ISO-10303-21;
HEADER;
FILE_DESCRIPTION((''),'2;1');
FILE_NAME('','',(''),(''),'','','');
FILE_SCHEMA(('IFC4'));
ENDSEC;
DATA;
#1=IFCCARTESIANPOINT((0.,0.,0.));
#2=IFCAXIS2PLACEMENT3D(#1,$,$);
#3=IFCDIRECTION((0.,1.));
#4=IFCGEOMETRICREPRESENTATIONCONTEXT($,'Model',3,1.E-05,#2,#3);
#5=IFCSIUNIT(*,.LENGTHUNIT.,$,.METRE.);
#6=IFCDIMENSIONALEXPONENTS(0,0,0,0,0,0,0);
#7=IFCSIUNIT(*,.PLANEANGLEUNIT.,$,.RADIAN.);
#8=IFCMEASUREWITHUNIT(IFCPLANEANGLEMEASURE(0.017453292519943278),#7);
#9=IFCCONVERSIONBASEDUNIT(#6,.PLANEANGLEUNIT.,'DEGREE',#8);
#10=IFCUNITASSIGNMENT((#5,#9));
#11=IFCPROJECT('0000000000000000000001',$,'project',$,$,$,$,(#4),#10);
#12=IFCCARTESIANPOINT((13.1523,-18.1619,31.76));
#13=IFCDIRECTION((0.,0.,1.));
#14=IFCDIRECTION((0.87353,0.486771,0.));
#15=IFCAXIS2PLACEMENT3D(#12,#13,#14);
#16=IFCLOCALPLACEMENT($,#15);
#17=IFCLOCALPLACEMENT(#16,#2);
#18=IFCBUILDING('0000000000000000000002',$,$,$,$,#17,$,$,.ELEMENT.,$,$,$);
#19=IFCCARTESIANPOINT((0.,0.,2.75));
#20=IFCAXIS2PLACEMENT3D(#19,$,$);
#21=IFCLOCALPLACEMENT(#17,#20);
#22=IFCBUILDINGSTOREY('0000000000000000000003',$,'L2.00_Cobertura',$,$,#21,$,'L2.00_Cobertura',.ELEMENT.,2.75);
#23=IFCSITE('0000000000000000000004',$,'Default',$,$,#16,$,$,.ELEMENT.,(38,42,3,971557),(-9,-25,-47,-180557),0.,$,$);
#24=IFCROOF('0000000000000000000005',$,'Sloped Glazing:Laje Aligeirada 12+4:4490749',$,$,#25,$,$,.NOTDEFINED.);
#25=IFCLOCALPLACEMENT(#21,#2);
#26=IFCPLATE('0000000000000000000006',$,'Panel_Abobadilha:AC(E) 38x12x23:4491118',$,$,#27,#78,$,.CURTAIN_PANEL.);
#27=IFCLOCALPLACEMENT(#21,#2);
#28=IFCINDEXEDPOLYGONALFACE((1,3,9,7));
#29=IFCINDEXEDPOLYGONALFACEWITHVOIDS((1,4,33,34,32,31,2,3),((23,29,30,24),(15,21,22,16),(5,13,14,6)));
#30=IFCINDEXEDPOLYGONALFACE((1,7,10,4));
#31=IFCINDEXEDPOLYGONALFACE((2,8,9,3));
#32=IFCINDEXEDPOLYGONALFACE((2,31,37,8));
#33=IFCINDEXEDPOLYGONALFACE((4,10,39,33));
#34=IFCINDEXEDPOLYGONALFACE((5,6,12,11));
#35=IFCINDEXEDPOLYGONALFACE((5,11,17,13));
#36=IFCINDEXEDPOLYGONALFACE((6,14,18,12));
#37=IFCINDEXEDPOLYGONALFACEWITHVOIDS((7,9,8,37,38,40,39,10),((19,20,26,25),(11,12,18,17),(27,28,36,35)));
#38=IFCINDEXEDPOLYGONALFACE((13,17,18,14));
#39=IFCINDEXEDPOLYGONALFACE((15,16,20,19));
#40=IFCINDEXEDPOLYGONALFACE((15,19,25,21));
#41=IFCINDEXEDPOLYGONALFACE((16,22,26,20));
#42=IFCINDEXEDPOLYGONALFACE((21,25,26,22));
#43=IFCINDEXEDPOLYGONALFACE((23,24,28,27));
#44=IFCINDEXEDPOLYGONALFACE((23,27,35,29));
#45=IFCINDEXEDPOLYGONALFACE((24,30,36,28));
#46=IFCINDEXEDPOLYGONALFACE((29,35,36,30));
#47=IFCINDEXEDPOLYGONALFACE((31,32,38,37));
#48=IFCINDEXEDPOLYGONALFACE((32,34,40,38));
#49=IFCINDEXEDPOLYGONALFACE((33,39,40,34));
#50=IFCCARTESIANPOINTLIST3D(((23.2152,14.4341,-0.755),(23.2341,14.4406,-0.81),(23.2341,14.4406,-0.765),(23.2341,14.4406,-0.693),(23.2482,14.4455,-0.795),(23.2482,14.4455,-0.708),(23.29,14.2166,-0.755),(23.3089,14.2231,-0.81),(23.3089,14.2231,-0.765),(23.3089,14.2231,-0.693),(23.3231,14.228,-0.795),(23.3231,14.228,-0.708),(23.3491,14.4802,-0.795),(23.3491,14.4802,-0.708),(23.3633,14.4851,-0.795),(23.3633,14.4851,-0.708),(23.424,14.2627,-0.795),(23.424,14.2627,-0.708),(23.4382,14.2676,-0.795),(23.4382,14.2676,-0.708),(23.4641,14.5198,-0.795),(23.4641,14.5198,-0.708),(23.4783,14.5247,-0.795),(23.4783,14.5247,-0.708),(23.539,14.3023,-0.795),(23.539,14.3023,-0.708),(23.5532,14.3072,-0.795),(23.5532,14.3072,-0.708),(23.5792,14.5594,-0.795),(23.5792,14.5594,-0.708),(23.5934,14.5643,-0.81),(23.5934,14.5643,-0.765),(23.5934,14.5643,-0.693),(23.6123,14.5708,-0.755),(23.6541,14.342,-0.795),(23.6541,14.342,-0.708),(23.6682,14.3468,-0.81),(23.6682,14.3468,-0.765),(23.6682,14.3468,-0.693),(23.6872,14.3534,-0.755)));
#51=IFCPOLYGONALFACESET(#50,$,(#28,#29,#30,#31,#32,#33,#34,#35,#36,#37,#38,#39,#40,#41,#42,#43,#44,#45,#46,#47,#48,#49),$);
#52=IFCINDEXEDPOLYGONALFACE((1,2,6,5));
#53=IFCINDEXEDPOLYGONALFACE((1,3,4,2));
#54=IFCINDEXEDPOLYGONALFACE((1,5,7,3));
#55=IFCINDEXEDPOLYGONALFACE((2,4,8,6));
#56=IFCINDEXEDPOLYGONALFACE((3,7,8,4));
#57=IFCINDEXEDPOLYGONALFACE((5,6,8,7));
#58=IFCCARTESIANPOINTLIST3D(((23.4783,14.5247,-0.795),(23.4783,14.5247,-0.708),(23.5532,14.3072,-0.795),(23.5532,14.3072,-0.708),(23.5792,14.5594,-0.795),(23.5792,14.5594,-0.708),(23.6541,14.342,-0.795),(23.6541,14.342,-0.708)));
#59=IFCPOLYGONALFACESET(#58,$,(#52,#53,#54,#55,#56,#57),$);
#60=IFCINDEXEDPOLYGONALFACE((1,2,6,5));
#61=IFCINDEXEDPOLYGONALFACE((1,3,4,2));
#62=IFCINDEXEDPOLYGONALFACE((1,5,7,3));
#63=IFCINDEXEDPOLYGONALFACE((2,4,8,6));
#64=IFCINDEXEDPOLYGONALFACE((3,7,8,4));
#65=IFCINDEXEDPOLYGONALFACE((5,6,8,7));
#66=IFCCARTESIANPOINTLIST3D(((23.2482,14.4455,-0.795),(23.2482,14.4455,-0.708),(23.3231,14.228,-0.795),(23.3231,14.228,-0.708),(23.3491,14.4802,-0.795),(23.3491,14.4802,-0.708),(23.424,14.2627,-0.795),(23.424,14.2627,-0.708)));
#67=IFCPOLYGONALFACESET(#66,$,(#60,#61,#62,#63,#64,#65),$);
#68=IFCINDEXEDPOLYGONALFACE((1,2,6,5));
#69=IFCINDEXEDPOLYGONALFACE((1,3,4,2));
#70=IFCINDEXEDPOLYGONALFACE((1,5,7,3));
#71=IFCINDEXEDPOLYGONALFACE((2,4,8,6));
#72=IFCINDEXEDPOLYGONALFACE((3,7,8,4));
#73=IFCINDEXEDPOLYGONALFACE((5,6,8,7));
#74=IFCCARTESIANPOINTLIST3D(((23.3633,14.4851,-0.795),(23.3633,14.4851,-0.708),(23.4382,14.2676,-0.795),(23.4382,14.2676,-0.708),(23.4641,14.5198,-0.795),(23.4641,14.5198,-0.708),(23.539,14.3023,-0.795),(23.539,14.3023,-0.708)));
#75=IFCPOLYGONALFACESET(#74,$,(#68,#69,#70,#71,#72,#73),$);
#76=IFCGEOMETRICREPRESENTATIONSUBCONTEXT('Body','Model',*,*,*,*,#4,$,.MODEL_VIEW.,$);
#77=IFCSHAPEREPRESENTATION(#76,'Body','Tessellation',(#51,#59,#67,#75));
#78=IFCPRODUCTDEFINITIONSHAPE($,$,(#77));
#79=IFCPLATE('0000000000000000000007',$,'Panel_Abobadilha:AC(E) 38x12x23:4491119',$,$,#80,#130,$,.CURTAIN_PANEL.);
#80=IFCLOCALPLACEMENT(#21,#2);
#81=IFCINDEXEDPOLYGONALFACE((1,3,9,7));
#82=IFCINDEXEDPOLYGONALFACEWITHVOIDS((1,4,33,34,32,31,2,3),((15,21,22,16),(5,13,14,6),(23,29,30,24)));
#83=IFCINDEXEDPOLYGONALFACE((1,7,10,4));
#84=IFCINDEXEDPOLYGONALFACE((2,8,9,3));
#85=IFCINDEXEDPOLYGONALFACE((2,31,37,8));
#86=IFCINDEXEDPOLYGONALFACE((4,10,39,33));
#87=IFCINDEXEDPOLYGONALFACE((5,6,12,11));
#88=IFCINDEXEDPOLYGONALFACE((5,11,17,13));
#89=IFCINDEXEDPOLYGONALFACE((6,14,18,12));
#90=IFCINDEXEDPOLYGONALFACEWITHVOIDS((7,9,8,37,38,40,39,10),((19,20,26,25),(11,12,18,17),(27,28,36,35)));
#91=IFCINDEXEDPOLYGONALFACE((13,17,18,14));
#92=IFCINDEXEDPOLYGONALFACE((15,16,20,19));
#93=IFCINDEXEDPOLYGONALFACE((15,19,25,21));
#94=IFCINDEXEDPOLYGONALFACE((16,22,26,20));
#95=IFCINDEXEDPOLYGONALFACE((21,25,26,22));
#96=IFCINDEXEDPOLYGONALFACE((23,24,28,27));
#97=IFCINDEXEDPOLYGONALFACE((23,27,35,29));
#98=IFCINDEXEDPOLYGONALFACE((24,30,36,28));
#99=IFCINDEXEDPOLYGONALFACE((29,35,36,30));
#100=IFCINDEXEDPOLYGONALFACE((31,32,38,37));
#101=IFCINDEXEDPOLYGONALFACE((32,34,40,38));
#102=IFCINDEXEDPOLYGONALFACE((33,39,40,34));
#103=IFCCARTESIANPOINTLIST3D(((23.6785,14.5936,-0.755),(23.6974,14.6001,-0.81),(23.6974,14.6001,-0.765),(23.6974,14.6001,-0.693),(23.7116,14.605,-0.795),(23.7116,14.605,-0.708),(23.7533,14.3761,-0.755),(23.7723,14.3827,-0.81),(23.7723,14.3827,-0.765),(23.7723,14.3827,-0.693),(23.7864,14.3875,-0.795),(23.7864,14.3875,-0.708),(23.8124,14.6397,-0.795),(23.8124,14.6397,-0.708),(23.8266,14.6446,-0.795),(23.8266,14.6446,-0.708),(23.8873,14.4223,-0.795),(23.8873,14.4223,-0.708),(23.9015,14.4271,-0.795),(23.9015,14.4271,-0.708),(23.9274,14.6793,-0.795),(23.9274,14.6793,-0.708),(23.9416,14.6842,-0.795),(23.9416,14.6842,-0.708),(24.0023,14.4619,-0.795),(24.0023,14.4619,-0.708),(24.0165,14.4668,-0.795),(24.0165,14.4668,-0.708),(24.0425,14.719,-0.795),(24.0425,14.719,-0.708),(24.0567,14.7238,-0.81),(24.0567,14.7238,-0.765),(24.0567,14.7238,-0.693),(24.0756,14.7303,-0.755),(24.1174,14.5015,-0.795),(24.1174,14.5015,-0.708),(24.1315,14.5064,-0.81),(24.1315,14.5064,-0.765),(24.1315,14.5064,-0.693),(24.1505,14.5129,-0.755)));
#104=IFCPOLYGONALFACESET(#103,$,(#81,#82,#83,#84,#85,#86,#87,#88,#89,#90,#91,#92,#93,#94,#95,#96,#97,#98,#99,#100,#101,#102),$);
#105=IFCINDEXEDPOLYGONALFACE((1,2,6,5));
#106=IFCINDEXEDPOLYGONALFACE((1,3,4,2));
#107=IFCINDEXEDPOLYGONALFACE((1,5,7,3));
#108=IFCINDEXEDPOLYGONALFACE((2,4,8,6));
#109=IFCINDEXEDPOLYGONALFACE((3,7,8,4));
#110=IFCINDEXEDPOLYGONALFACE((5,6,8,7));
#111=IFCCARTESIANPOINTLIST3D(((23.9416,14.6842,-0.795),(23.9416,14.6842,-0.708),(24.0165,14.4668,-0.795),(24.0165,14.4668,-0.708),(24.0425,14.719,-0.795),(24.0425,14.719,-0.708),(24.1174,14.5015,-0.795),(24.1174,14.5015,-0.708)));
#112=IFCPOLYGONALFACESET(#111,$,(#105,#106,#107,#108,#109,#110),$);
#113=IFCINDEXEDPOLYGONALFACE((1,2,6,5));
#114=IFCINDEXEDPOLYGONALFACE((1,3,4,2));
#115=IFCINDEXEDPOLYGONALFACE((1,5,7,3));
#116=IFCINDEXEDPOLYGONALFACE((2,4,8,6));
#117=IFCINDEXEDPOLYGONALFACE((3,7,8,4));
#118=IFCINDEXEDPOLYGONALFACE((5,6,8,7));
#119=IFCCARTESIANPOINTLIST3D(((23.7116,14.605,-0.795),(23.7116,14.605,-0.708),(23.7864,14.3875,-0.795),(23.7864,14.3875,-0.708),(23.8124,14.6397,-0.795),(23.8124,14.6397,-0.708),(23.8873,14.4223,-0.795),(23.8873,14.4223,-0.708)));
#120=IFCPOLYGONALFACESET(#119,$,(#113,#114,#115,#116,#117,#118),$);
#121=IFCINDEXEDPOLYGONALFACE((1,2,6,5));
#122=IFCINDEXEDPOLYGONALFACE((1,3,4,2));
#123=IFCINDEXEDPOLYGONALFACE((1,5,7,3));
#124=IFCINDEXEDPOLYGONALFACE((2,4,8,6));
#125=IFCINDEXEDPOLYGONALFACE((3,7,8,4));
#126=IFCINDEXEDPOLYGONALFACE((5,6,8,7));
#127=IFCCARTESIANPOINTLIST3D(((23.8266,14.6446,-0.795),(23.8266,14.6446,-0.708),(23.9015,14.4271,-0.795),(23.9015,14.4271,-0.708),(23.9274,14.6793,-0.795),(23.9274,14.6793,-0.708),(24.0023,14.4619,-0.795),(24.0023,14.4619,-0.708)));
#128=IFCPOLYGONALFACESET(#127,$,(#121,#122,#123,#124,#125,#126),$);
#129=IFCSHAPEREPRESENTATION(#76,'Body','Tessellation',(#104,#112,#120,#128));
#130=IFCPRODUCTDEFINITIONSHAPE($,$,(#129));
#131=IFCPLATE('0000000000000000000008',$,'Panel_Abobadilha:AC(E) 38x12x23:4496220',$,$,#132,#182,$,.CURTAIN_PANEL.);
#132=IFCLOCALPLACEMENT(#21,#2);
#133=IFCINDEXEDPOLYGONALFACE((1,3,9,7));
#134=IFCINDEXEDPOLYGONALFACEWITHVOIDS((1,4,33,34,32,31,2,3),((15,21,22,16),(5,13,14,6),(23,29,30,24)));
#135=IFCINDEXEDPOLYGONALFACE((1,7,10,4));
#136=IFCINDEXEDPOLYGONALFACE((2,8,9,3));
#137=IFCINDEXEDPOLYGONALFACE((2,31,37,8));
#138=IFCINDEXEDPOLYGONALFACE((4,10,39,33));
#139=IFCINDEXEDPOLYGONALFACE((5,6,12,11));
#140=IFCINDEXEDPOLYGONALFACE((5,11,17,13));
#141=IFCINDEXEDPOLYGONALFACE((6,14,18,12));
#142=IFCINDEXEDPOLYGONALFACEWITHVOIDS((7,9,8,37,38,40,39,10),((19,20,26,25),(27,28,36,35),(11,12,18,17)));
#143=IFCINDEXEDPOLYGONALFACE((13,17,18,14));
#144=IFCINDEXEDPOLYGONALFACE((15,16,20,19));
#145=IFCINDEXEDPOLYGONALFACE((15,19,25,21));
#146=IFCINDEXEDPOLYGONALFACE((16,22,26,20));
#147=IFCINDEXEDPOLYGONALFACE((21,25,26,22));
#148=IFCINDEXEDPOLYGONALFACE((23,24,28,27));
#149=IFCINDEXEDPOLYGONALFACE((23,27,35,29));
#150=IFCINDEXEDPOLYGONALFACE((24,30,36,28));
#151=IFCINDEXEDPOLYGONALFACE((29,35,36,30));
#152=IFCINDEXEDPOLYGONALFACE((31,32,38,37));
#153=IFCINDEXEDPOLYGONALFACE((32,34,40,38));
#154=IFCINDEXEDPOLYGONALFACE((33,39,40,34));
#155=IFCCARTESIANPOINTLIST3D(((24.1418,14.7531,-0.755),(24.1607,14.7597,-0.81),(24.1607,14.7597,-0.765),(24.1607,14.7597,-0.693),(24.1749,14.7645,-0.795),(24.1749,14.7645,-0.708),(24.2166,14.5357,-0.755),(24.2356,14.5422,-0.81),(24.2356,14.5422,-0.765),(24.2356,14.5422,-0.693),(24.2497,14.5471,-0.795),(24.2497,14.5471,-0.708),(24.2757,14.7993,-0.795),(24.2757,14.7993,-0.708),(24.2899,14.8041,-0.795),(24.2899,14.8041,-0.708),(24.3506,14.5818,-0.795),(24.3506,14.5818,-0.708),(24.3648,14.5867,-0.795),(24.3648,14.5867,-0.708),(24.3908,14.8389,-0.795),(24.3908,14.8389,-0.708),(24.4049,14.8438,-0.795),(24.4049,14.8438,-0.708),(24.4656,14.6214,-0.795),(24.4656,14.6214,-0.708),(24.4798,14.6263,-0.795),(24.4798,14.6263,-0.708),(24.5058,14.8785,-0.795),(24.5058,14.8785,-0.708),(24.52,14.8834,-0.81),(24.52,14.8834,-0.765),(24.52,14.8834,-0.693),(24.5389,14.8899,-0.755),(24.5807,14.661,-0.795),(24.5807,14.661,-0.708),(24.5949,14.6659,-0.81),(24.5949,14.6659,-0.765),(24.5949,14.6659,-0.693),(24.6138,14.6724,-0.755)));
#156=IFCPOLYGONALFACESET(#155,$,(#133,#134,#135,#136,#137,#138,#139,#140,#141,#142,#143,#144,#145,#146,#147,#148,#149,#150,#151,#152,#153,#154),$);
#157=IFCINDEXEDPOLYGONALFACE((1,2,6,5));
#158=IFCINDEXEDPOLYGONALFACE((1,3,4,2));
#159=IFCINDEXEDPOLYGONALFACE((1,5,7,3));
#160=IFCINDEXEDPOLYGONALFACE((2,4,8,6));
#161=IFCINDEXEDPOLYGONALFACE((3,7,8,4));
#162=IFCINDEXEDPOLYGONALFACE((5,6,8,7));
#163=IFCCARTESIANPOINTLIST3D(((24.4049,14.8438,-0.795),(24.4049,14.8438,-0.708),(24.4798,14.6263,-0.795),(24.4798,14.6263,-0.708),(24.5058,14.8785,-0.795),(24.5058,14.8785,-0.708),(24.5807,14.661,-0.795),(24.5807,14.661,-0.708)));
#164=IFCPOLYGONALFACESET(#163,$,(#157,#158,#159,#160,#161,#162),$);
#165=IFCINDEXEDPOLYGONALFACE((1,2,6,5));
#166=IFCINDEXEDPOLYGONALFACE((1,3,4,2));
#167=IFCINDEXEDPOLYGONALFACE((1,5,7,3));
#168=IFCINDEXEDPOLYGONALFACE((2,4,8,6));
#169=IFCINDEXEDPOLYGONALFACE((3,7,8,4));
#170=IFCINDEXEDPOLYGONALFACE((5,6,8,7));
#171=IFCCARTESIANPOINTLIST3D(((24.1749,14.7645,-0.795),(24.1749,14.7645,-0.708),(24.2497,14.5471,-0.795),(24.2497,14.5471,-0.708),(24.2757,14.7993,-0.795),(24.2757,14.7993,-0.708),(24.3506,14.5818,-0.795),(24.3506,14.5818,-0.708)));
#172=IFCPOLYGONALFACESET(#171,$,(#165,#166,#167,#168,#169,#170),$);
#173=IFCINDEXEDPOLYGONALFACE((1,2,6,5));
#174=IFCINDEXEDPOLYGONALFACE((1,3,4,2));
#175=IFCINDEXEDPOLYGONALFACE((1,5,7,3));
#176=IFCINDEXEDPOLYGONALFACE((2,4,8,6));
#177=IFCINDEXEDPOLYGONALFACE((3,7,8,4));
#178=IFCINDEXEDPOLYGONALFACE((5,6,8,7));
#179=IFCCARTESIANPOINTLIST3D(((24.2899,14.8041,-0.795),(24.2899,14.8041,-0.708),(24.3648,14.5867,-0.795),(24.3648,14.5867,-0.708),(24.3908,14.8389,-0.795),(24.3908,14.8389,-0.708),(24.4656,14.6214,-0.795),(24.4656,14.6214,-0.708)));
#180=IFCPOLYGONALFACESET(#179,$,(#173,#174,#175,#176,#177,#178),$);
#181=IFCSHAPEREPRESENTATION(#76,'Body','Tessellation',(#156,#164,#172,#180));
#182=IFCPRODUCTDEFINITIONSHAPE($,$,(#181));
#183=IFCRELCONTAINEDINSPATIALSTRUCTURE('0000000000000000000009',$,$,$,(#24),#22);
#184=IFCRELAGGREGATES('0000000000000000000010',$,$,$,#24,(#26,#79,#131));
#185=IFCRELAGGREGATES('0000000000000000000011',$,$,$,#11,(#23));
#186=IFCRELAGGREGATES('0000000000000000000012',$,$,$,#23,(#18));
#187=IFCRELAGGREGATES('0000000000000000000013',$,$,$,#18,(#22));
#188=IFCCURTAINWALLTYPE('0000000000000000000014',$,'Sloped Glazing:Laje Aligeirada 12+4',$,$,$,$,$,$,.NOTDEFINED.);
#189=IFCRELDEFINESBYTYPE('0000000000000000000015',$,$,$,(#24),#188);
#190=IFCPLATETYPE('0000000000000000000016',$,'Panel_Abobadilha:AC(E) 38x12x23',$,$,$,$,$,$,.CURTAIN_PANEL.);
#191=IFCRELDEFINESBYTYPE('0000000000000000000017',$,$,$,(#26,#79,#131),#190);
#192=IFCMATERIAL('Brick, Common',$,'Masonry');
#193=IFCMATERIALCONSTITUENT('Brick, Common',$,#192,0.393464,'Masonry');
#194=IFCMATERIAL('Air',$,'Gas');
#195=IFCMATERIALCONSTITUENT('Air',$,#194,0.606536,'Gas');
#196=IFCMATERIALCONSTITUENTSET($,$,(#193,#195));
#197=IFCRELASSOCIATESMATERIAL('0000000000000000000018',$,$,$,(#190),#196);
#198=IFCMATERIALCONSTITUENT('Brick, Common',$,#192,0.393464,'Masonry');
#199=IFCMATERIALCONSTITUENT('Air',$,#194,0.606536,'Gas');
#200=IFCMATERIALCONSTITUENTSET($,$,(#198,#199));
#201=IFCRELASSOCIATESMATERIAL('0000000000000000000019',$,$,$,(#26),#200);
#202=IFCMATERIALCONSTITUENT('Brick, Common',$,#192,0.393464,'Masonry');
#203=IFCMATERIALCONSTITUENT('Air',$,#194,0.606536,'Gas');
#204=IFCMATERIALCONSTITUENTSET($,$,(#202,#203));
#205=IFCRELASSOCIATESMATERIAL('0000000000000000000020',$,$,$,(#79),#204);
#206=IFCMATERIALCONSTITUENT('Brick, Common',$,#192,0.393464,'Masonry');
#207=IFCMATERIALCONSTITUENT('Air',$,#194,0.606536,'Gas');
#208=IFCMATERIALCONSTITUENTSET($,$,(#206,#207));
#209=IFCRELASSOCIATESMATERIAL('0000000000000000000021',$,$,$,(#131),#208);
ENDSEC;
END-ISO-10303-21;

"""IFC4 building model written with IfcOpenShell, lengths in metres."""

from ifc_helpers import new_model, entity, si_unit, converted_unit, direction, frame, origin, place, context, subcontext, project, spatial, indexed_curve, outline, extrude, source, transform, mapped, material, constituent, constituent_set, type_object, type_shapes, element, aggregate, save


model = new_model("IFC4")

# Units and contexts
model_context = context("Model", 3, precision=1e-05, world=origin(), true_north=direction((0.0, 1.0)))
body_context = subcontext(model_context, "Body", "Model", "MODEL_VIEW")
ifc_project = project(units=[si_unit("LENGTHUNIT", "METRE"), converted_unit("PLANEANGLEUNIT", "DEGREE", entity("IfcPlaneAngleMeasure", 0.017453292519943278), si_unit("PLANEANGLEUNIT", "RADIAN"), dimensions=[0, 0, 0, 0, 0, 0, 0])], contexts=[model_context])

# Site, building, storey
site_placement = place(None, frame((13.1523, -18.1619, 31.76), z_axis=(0.0, 0.0, 1.0), x_axis=(0.87353, 0.486771, 0.0)))
site = spatial("IfcSite", under=ifc_project, at=site_placement, Name="Default", CompositionType="ELEMENT", RefLatitude=(38, 42, 3, 971557), RefLongitude=(-9, -25, -47, -180557), RefElevation=0.0)
building_placement = place(site_placement, origin())
building = spatial("IfcBuilding", under=site, at=building_placement, CompositionType="ELEMENT")
storey_placement = place(building_placement, frame((0.0, 0.0, 2.75)))
storey = spatial("IfcBuildingStorey", under=building, at=storey_placement, Name="L2.00_Cobertura", LongName="L2.00_Cobertura", CompositionType="ELEMENT", Elevation=2.75)

# Roof, plates
curtain_wall_type = type_object("IfcCurtainWallType", Name="Sloped Glazing:Laje Aligeirada 12+4", PredefinedType="NOTDEFINED")
roof_placement = place(storey_placement, frame((0.0, 0.0, -2.75)))
roof = element("IfcRoof", 1, at=roof_placement, inside=storey, type_object=curtain_wall_type, Name="Sloped Glazing:Laje Aligeirada 12+4:4490749", PredefinedType="NOTDEFINED")
ifc_material_1 = material(Name="Brick, Common", Category="Masonry")
ifc_material_2 = material(Name="Air", Category="Gas")
ifc_constituent_1 = constituent(ifc_material_1, Name="Brick, Common", Category="Masonry", fraction=0.393464)
ifc_constituent_2 = constituent(ifc_material_2, Name="Air", Category="Gas", fraction=0.606536)
ifc_constituent_set_1 = constituent_set(constituents=[ifc_constituent_1, ifc_constituent_2])
plate_type = type_object("IfcPlateType", Name="Panel_Abobadilha:AC(E) 38x12x23", PredefinedType="CURTAIN_PANEL", material=ifc_constituent_set_1)
shared_shape_1 = source(origin(), body_context, "Body", "SweptSolid", [
    extrude(outline(indexed_curve([(-0.19, -0.0543), (0.19, -0.0543), (0.19, -0.0093), (0.21, 0.0007), (0.19, 0.0628), (-0.19, 0.0628), (-0.21, 0.0007), (-0.19, -0.0093), (-0.19, -0.0543)], self_intersect=False), holes=[indexed_curve([(-0.0683, 0.0477), (-0.0683, -0.0393), (-0.175, -0.0393), (-0.175, 0.0477), (-0.0683, 0.0477)], self_intersect=False), indexed_curve([(0.0533, 0.0477), (0.0533, -0.0393), (-0.0533, -0.0393), (-0.0533, 0.0477), (0.0533, 0.0477)], self_intersect=False), indexed_curve([(0.175, 0.0477), (0.175, -0.0393), (0.0683, -0.0393), (0.0683, 0.0477), (0.175, 0.0477)], self_intersect=False)]), frame((0.0, 0.0543, 0.0)), (0.0, 0.0, 1.0), 0.23),
    extrude(outline(indexed_curve([(-0.0533, -0.0435), (0.0533, -0.0435), (0.0533, 0.0435), (-0.0533, 0.0435), (-0.0533, -0.0435)], self_intersect=False)), frame((0.1217, 0.0585, 0.0), z_axis=(0.0, 0.0, 1.0), x_axis=(-1.0, 0.0, 0.0)), (0.0, 0.0, 1.0), 0.23),
    extrude(outline(indexed_curve([(-0.0533, -0.0435), (0.0533, -0.0435), (0.0533, 0.0435), (-0.0533, 0.0435), (-0.0533, -0.0435)], self_intersect=False)), frame((-0.1217, 0.0585, 0.0), z_axis=(0.0, 0.0, 1.0), x_axis=(-1.0, 0.0, 0.0)), (0.0, 0.0, 1.0), 0.23),
    extrude(outline(indexed_curve([(-0.0533, -0.0435), (0.0533, -0.0435), (0.0533, 0.0435), (-0.0533, 0.0435), (-0.0533, -0.0435)], self_intersect=False)), frame((0.0, 0.0585, 0.0), z_axis=(0.0, 0.0, 1.0), x_axis=(-1.0, 0.0, 0.0)), (0.0, 0.0, 1.0), 0.23),
])
type_shapes(plate_type, [shared_shape_1])
ifc_constituent_3 = constituent(ifc_material_1, Name="Brick, Common", Category="Masonry", fraction=0.393464)
ifc_constituent_4 = constituent(ifc_material_2, Name="Air", Category="Gas", fraction=0.606536)
ifc_constituent_set_2 = constituent_set(constituents=[ifc_constituent_3, ifc_constituent_4])
plate_1_placement = place(roof_placement, frame((23.4137, 14.5025, 1.94), z_axis=(0.325568, -0.945519, 0.0), x_axis=(0.945519, 0.325568, 0.0)))
plate_1 = element("IfcPlate", 2, at=plate_1_placement, type_object=plate_type, material=ifc_constituent_set_2, Name="Panel_Abobadilha:AC(E) 38x12x23:4491118", PredefinedType="CURTAIN_PANEL", context=body_context, shape_type="MappedRepresentation", body=[
    mapped(shared_shape_1, transform((0.0, 0.0, 0.0), scale=1.0)),
])
ifc_constituent_5 = constituent(ifc_material_1, Name="Brick, Common", Category="Masonry", fraction=0.393464)
ifc_constituent_6 = constituent(ifc_material_2, Name="Air", Category="Gas", fraction=0.606536)
ifc_constituent_set_3 = constituent_set(constituents=[ifc_constituent_5, ifc_constituent_6])
plate_2_placement = place(roof_placement, frame((23.877, 14.662, 1.94), z_axis=(0.325568, -0.945519, 0.0), x_axis=(0.945519, 0.325568, 0.0)))
plate_2 = element("IfcPlate", 3, at=plate_2_placement, type_object=plate_type, material=ifc_constituent_set_3, Name="Panel_Abobadilha:AC(E) 38x12x23:4491119", PredefinedType="CURTAIN_PANEL", context=body_context, shape_type="MappedRepresentation", body=[
    mapped(shared_shape_1, transform((0.0, 0.0, 0.0), scale=1.0)),
])
ifc_constituent_7 = constituent(ifc_material_1, Name="Brick, Common", Category="Masonry", fraction=0.393464)
ifc_constituent_8 = constituent(ifc_material_2, Name="Air", Category="Gas", fraction=0.606536)
ifc_constituent_set_4 = constituent_set(constituents=[ifc_constituent_7, ifc_constituent_8])
plate_3_placement = place(roof_placement, frame((24.3403, 14.8215, 1.94), z_axis=(0.325568, -0.945519, 0.0), x_axis=(0.945519, 0.325568, 0.0)))
plate_3 = element("IfcPlate", 4, at=plate_3_placement, type_object=plate_type, material=ifc_constituent_set_4, Name="Panel_Abobadilha:AC(E) 38x12x23:4496220", PredefinedType="CURTAIN_PANEL", context=body_context, shape_type="MappedRepresentation", body=[
    mapped(shared_shape_1, transform((0.0, 0.0, 0.0), scale=1.0)),
])
aggregate(roof, [plate_1, plate_2, plate_3])

save(model, "model.ifc")
